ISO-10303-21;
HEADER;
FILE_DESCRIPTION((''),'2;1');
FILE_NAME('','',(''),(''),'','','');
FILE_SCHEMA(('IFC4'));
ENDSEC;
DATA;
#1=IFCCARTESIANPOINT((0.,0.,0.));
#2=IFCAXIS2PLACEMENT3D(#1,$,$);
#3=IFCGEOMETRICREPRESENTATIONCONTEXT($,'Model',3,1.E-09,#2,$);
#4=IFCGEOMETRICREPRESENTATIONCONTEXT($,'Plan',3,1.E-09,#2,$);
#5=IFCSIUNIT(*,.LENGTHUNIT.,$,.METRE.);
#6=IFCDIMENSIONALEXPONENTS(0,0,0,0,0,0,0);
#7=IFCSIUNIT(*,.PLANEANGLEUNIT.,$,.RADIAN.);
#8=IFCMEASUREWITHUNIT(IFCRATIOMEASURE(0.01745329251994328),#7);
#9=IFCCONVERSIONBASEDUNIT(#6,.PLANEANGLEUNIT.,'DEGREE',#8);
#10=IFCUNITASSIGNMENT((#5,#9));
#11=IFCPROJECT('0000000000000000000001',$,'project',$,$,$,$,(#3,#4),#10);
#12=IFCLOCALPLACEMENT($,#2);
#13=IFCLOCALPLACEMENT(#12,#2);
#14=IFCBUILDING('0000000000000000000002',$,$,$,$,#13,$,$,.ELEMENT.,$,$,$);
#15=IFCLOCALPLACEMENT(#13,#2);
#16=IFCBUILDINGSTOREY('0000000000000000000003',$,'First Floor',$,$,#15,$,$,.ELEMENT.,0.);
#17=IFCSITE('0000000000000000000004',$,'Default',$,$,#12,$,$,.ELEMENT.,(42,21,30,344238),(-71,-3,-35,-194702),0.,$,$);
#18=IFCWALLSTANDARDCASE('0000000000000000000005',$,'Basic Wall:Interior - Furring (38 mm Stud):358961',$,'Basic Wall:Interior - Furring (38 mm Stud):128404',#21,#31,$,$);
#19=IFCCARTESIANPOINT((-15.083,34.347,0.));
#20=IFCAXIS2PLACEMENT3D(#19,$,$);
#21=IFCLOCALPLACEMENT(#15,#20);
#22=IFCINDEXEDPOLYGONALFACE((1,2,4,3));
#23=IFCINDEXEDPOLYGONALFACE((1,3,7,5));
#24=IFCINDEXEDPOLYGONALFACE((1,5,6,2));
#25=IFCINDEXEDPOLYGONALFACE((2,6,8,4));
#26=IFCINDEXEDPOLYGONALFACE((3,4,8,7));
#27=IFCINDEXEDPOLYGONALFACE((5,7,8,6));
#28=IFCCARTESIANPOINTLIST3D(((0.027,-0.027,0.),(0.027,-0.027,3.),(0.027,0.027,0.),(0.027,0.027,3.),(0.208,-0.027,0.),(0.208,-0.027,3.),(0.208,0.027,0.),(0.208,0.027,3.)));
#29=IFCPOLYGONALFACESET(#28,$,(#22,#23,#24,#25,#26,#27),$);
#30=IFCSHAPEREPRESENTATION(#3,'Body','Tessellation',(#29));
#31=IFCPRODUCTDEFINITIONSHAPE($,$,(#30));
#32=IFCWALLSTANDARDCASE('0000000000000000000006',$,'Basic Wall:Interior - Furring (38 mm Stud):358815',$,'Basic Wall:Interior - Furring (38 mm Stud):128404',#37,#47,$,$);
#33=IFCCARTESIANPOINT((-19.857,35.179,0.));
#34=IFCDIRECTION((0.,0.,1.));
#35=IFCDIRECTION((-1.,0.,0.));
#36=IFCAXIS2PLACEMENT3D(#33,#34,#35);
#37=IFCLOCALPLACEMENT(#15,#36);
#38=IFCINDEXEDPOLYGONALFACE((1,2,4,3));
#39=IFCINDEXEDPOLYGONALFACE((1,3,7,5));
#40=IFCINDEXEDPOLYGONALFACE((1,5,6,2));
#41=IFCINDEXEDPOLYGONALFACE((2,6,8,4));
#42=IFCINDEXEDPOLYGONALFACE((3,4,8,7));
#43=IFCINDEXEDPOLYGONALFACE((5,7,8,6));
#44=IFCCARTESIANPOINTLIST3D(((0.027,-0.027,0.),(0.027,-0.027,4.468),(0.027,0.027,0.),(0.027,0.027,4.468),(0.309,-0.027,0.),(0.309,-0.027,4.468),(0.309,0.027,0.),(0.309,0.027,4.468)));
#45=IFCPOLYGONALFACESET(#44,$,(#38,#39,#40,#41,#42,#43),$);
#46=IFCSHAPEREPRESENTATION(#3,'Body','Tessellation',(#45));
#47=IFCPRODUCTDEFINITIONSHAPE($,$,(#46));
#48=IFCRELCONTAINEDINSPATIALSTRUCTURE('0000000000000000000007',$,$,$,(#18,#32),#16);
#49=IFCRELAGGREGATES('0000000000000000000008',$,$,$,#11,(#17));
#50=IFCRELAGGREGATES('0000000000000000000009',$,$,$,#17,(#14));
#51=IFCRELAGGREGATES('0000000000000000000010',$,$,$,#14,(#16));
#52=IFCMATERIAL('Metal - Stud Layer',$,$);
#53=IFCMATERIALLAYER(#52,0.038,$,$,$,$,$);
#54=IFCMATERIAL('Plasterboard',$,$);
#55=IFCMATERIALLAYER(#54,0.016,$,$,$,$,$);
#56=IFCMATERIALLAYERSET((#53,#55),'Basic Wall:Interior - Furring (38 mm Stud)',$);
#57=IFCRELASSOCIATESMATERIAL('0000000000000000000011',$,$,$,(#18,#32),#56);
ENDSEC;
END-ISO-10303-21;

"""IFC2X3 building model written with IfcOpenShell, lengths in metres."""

from ifc_helpers import new_model, entity, si_unit, converted_unit, frame, frame_2d, origin, place, context, project, spatial, rectangle, extrude, material, layer, layer_set, layer_usage, element, save


model = new_model("IFC2X3")

# Units and contexts
model_context = context("Model", 3, precision=1e-09, world=origin())
plan_context = context("Plan", 3, precision=1e-09, world=origin())
ifc_project = project(units=[si_unit("LENGTHUNIT", "METRE"), converted_unit("PLANEANGLEUNIT", "DEGREE", entity("IfcRatioMeasure", 0.01745329251994328), si_unit("PLANEANGLEUNIT", "RADIAN"), dimensions=[0, 0, 0, 0, 0, 0, 0])], contexts=[model_context, plan_context])

# Site, building, storey
site_placement = place(None, origin())
site = spatial("IfcSite", under=ifc_project, at=site_placement, Name="Default", CompositionType="ELEMENT", RefLatitude=(42, 21, 30, 344238), RefLongitude=(-71, -3, -35, -194702), RefElevation=0.0)
building_placement = place(site_placement, origin())
building = spatial("IfcBuilding", under=site, at=building_placement, CompositionType="ELEMENT")
storey_placement = place(building_placement, origin())
storey = spatial("IfcBuildingStorey", under=building, at=storey_placement, Name="First Floor", CompositionType="ELEMENT", Elevation=0.0)

# Shared definitions
ifc_material_1 = material(Name="Plasterboard")
ifc_material_2 = material(Name="Metal - Stud Layer")

# Walls
ifc_layer_1 = layer(ifc_material_2, 0.038)
ifc_layer_2 = layer(ifc_material_1, 0.016)
ifc_layer_set_1 = layer_set([ifc_layer_1, ifc_layer_2], Name="Basic Wall:Interior - Furring (38 mm Stud)")
ifc_layer_usage_1 = layer_usage(ifc_layer_set_1, "AXIS2", "NEGATIVE", 0.027)
wall_1_placement = place(storey_placement, frame((-15.083, 34.347, 0.0)))
element("IfcWallStandardCase", 1, at=wall_1_placement, inside=storey, material=ifc_layer_usage_1, Name="Basic Wall:Interior - Furring (38 mm Stud):358961", ObjectType="Basic Wall:Interior - Furring (38 mm Stud):128404", context=model_context, shape_type="SweptSolid", body=[
    extrude(rectangle(XDim=0.181, YDim=0.054, at=frame_2d((0.1175, 0.0), x_axis=(-1.0, 0.0))), origin(), (0.0, 0.0, 1.0), 3.0),
])
wall_2_placement = place(storey_placement, frame((-19.857, 35.179, 0.0), z_axis=(0.0, 0.0, 1.0), x_axis=(-1.0, 0.0, 0.0)))
element("IfcWallStandardCase", 2, at=wall_2_placement, inside=storey, material=ifc_layer_usage_1, Name="Basic Wall:Interior - Furring (38 mm Stud):358815", ObjectType="Basic Wall:Interior - Furring (38 mm Stud):128404", context=model_context, shape_type="SweptSolid", body=[
    extrude(rectangle(XDim=0.282, YDim=0.054, at=frame_2d((0.168, 0.0), x_axis=(-1.0, 0.0))), origin(), (0.0, 0.0, 1.0), 4.468),
])

save(model, "model.ifc")
